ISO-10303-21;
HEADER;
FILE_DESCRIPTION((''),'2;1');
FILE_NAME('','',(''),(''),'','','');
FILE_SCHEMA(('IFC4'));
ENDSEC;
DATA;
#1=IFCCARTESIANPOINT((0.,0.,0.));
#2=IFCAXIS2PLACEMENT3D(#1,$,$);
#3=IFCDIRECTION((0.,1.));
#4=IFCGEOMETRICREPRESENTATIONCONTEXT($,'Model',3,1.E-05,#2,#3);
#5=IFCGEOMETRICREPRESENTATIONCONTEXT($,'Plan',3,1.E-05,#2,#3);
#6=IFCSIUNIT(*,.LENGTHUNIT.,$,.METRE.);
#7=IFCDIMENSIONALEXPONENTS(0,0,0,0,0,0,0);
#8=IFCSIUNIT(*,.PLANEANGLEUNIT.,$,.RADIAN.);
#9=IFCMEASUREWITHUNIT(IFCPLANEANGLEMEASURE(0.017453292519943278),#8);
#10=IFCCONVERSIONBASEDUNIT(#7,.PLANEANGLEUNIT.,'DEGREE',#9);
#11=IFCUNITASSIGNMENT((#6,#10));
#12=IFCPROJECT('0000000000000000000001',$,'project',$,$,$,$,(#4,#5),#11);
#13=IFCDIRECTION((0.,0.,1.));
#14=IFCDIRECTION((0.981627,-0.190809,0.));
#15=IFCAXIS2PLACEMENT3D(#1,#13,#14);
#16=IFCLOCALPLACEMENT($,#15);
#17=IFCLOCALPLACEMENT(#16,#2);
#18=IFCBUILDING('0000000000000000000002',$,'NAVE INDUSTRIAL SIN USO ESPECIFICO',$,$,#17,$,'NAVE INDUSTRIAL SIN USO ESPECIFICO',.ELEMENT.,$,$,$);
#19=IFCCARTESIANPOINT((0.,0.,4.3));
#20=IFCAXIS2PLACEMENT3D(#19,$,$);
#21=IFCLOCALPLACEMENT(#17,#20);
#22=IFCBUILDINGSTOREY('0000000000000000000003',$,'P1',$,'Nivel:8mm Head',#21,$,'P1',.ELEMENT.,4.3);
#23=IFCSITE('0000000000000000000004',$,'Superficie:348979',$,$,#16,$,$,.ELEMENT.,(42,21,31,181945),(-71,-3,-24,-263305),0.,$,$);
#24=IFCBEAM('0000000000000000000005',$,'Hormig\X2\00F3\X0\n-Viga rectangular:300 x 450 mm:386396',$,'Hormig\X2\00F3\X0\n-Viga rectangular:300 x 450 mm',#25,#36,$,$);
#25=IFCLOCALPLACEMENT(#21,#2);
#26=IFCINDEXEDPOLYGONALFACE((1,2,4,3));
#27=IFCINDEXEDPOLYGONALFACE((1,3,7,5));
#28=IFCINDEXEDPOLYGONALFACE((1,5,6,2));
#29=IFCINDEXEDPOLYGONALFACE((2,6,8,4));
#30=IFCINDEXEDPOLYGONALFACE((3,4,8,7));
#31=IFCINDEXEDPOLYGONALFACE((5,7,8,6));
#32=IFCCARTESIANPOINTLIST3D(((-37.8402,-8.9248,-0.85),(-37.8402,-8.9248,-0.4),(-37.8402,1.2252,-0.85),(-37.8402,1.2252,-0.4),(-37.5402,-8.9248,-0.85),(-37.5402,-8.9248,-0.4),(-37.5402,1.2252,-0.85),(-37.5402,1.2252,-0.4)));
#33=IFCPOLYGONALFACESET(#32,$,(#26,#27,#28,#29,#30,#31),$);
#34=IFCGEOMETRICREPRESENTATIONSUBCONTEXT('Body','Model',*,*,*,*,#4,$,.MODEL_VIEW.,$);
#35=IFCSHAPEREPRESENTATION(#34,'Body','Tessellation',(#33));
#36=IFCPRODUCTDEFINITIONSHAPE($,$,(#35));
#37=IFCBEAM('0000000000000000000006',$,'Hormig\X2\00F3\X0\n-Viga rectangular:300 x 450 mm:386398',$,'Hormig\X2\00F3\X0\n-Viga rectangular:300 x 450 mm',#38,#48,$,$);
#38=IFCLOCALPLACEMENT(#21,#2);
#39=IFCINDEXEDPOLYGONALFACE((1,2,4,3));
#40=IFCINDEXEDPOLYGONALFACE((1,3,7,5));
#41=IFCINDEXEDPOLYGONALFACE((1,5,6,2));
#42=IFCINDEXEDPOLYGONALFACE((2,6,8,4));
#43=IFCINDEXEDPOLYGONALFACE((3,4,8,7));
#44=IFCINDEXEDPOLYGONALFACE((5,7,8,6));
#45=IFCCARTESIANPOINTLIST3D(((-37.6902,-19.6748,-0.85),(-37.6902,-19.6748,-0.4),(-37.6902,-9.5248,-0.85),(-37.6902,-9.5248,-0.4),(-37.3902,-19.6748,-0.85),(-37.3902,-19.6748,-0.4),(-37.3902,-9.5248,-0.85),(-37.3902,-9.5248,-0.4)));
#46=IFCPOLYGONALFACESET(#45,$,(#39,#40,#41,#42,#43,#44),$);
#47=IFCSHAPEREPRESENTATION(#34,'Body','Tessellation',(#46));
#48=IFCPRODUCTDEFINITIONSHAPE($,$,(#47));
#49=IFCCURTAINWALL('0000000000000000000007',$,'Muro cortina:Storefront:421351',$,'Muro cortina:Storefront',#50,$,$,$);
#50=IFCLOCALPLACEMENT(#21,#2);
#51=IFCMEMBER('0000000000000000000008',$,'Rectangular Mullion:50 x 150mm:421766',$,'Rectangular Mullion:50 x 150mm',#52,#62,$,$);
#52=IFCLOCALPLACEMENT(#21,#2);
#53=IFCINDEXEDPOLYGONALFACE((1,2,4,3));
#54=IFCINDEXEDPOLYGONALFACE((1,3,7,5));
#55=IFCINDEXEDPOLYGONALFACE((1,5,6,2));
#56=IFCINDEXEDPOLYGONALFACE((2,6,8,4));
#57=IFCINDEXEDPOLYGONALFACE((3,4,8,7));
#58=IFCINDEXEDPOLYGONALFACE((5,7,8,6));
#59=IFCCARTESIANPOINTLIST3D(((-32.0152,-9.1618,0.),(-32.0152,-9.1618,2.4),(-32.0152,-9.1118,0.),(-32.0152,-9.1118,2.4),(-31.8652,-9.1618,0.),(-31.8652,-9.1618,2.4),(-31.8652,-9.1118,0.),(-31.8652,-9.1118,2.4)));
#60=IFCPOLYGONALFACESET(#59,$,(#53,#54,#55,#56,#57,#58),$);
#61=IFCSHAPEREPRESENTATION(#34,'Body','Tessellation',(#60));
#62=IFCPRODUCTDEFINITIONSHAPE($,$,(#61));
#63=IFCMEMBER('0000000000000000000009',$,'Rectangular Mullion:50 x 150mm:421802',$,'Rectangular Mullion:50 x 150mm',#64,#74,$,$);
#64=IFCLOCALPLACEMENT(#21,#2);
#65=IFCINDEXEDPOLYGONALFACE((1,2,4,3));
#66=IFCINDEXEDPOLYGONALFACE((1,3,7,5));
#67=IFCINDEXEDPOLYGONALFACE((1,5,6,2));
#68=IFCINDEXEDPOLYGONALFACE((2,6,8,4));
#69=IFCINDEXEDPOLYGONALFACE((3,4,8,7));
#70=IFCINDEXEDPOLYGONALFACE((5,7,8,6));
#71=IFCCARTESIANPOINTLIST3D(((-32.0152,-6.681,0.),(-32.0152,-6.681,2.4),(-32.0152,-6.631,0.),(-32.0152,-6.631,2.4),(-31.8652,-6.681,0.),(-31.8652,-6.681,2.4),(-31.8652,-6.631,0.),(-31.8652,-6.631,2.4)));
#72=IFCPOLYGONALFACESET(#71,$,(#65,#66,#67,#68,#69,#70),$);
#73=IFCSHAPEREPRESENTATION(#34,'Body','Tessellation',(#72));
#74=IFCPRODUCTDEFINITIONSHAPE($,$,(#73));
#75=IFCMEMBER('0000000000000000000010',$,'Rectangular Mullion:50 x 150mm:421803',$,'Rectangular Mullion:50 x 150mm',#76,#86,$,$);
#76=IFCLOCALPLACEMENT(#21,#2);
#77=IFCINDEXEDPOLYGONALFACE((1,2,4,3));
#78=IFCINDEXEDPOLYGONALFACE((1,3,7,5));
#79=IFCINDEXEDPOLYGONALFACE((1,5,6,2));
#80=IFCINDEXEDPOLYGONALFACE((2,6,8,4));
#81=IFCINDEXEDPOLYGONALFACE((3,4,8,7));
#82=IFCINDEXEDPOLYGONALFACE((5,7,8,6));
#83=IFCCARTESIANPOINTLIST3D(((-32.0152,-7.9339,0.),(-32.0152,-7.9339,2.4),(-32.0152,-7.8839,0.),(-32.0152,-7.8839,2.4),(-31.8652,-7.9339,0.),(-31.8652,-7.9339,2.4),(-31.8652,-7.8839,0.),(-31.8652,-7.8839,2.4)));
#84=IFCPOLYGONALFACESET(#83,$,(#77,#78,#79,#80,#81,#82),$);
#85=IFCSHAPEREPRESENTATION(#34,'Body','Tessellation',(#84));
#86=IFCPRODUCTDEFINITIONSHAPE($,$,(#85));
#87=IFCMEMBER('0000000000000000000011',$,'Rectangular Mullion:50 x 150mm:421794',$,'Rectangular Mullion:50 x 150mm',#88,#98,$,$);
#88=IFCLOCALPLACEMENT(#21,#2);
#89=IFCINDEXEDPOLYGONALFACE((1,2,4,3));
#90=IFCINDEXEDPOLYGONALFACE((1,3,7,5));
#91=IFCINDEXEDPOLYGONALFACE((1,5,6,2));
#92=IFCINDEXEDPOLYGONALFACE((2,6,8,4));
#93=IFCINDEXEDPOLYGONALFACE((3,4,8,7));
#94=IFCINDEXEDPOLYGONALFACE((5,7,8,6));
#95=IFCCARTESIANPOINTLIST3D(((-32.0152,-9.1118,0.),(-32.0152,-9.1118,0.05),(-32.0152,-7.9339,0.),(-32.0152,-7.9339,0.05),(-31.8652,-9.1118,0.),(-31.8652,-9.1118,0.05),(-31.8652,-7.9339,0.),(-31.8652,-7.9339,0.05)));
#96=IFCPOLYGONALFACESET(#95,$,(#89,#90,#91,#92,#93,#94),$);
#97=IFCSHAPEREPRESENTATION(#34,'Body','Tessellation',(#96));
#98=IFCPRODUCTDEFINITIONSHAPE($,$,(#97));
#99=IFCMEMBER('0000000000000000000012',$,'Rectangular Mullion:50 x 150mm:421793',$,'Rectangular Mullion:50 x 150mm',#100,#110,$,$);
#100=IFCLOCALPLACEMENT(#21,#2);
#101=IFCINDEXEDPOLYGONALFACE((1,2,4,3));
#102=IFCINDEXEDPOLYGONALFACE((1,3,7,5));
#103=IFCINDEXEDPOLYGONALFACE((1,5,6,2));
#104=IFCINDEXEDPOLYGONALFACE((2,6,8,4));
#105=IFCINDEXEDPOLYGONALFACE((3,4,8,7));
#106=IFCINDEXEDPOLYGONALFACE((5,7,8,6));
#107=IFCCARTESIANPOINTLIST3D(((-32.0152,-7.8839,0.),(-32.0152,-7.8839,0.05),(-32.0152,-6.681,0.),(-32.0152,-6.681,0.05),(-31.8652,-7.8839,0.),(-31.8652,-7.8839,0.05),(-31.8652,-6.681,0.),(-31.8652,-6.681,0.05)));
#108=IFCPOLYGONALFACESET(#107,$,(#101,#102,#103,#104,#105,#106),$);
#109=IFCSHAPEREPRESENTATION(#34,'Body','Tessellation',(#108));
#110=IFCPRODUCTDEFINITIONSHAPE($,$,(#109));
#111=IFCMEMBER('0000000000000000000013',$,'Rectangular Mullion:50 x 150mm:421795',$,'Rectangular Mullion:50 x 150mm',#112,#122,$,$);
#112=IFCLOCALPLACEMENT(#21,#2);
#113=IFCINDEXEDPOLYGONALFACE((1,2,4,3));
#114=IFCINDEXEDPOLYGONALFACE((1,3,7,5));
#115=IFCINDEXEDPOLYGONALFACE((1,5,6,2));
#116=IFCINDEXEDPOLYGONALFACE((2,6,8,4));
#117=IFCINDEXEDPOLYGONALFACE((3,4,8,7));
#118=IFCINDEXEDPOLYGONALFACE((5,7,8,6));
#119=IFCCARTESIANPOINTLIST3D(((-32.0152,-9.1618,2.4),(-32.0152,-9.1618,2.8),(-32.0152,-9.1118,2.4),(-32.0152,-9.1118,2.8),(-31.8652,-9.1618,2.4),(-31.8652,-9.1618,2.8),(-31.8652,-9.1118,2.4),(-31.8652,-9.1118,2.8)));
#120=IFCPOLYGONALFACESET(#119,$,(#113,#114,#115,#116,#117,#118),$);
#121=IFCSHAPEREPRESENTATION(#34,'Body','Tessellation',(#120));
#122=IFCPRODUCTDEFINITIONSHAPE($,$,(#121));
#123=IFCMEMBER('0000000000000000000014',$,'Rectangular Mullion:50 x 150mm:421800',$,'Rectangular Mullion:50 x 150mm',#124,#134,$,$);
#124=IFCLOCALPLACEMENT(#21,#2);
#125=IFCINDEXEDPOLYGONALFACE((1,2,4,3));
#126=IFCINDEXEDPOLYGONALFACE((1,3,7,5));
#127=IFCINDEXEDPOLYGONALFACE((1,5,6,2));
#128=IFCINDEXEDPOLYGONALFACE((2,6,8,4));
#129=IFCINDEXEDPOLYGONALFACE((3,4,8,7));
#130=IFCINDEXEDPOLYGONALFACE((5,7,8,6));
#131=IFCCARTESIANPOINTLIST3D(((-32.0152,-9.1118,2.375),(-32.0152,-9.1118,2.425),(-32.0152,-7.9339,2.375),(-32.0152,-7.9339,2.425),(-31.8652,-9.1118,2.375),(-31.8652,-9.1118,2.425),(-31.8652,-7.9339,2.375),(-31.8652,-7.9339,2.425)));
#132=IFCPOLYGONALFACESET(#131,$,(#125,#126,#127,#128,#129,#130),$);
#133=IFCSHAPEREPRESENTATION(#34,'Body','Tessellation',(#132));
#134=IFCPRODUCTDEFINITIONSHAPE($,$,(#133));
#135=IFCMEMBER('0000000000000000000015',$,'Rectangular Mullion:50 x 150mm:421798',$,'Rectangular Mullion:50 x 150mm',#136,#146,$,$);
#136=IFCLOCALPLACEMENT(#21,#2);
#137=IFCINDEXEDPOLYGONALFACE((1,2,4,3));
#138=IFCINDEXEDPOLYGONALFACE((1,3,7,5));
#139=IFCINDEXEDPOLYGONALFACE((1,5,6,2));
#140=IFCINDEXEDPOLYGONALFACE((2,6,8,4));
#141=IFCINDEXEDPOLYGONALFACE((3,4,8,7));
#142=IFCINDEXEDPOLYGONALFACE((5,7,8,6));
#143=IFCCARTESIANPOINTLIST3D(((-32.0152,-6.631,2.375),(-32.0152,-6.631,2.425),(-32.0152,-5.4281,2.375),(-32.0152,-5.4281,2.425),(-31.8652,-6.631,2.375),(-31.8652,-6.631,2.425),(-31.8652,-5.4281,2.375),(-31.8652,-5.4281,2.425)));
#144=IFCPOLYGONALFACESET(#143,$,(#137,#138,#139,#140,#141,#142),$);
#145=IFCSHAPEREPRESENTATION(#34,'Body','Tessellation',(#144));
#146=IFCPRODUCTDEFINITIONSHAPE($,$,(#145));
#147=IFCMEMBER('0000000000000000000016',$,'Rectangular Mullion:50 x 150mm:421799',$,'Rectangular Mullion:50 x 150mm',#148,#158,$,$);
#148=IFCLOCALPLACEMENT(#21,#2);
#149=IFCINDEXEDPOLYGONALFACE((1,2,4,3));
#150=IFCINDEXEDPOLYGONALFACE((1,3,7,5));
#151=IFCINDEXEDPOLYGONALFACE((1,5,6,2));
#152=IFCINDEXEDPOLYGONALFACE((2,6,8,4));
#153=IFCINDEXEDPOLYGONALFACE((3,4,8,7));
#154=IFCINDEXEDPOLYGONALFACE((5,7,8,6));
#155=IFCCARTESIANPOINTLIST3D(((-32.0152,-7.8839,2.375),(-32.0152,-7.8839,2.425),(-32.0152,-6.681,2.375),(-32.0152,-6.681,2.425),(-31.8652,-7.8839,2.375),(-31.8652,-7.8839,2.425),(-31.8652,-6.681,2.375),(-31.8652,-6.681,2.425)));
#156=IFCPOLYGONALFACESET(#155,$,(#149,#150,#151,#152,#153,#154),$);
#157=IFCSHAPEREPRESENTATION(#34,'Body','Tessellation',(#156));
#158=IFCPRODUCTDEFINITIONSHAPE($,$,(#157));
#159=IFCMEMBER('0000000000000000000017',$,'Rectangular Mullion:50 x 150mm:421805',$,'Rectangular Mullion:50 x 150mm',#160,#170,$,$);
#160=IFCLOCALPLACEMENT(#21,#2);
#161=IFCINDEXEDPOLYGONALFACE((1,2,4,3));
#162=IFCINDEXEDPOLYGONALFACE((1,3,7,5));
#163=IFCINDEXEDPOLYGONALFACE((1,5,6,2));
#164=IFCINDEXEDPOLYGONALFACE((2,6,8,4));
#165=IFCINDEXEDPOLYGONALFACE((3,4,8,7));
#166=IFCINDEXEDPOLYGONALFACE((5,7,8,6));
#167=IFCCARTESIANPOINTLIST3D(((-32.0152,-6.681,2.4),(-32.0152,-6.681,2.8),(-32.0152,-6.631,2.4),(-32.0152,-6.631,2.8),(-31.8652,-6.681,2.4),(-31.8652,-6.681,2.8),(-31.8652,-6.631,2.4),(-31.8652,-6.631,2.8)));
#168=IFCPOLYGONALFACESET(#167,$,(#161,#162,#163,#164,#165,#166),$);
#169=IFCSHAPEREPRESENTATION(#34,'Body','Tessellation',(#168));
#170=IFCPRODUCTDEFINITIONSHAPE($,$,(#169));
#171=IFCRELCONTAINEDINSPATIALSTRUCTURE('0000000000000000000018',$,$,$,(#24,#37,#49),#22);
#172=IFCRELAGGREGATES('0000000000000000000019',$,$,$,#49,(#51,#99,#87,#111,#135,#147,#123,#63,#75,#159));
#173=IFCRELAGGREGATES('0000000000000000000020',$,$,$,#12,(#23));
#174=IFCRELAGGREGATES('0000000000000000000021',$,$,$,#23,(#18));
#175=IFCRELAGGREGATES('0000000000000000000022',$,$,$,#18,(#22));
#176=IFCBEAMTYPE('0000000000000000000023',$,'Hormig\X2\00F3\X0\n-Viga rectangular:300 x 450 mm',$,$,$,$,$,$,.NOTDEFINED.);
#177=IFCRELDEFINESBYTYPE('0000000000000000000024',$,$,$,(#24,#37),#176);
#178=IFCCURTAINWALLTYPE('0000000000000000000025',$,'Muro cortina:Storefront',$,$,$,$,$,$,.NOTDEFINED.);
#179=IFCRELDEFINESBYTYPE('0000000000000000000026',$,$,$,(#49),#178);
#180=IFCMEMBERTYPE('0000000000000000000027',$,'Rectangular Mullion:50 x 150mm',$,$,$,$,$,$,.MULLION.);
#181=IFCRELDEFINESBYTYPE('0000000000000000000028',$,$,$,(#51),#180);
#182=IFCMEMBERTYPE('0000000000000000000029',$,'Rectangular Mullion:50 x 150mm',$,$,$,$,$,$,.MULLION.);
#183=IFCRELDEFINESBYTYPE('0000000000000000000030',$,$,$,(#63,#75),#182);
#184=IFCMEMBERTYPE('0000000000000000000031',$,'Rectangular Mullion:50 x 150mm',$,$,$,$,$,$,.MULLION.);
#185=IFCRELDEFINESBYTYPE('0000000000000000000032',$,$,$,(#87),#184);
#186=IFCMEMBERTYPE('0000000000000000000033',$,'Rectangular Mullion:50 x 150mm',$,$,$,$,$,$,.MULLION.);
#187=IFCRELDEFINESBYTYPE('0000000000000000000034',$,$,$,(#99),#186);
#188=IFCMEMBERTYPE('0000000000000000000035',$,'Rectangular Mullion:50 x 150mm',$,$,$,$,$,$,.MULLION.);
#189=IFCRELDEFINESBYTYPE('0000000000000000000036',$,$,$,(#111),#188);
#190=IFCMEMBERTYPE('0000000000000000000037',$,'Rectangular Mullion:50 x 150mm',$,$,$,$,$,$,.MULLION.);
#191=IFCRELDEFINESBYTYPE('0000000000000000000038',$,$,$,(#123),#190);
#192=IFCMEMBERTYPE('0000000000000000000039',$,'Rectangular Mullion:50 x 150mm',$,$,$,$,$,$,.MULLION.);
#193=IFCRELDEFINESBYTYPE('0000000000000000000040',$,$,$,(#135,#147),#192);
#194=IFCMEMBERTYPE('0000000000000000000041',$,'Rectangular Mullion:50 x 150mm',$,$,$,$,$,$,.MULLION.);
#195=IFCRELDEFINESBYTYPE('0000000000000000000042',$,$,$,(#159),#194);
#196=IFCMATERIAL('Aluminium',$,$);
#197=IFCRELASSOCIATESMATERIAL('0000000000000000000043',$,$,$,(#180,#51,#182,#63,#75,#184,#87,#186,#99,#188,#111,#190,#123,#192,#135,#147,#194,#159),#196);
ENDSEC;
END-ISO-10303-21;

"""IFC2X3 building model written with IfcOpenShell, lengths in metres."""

from ifc_helpers import new_model, entity, si_unit, converted_unit, direction, frame, frame_2d, origin, origin_2d_with_axis, place, context, subcontext, project, spatial, rectangle, extrude, source, transform, mapped, material, type_object, type_shapes, element, aggregate, save


model = new_model("IFC2X3")

# Units and contexts
model_context = context("Model", 3, precision=1e-05, world=origin(), true_north=direction((0.0, 1.0)))
plan_context = context("Plan", 3, precision=1e-05, world=origin(), true_north=direction((0.0, 1.0)))
body_context = subcontext(model_context, "Body", "Model", "MODEL_VIEW")
ifc_project = project(units=[si_unit("LENGTHUNIT", "METRE"), converted_unit("PLANEANGLEUNIT", "DEGREE", entity("IfcPlaneAngleMeasure", 0.017453292519943278), si_unit("PLANEANGLEUNIT", "RADIAN"), dimensions=[0, 0, 0, 0, 0, 0, 0])], contexts=[model_context, plan_context])

# Site, building, storey
site_placement = place(None, frame((0.0, 0.0, 0.0), z_axis=(0.0, 0.0, 1.0), x_axis=(0.981627, -0.190809, 0.0)))
site = spatial("IfcSite", under=ifc_project, at=site_placement, Name="Superficie:348979", CompositionType="ELEMENT", RefLatitude=(42, 21, 31, 181945), RefLongitude=(-71, -3, -24, -263305), RefElevation=0.0)
building_placement = place(site_placement, origin())
building = spatial("IfcBuilding", under=site, at=building_placement, Name="NAVE INDUSTRIAL SIN USO ESPECIFICO", LongName="NAVE INDUSTRIAL SIN USO ESPECIFICO", CompositionType="ELEMENT")
storey_placement = place(building_placement, frame((0.0, 0.0, 4.3)))
storey = spatial("IfcBuildingStorey", under=building, at=storey_placement, Name="P1", ObjectType="Nivel:8mm Head", LongName="P1", CompositionType="ELEMENT", Elevation=4.3)

# Beams
beam_type = type_object("IfcBeamType", Name="Hormigón-Viga rectangular:300 x 450 mm", PredefinedType="NOTDEFINED")
beam_1_placement = place(storey_placement, frame((-37.6902, 1.5252, -0.4), z_axis=(0.0, 0.0, 1.0), x_axis=(0.0, -1.0, 0.0)))
element("IfcBeam", 1, at=beam_1_placement, inside=storey, type_object=beam_type, Name="Hormigón-Viga rectangular:300 x 450 mm:386396", ObjectType="Hormigón-Viga rectangular:300 x 450 mm", context=body_context, shape_type="SweptSolid", body=[
    extrude(rectangle(XDim=0.45, YDim=0.3, at=frame_2d((0.0, 0.0), x_axis=(1.0, 0.0))), frame((0.3, 0.0, -0.225), z_axis=(1.0, 0.0, 0.0), x_axis=(0.0, 0.0, -1.0)), (0.0, 0.0, 1.0), 10.15),
])
beam_2_placement = place(storey_placement, frame((-37.5402, -9.2248, -0.4), z_axis=(0.0, 0.0, 1.0), x_axis=(0.0, -1.0, 0.0)))
element("IfcBeam", 2, at=beam_2_placement, inside=storey, type_object=beam_type, Name="Hormigón-Viga rectangular:300 x 450 mm:386398", ObjectType="Hormigón-Viga rectangular:300 x 450 mm", context=body_context, shape_type="SweptSolid", body=[
    extrude(rectangle(XDim=0.45, YDim=0.3, at=frame_2d((0.0, 0.0), x_axis=(1.0, 0.0))), frame((0.3, 0.0, -0.225), z_axis=(1.0, 0.0, 0.0), x_axis=(0.0, 0.0, -1.0)), (0.0, 0.0, 1.0), 10.15),
])

# Curtain wall, members
curtain_wall_type = type_object("IfcCurtainWallType", Name="Muro cortina:Storefront", PredefinedType="NOTDEFINED")
curtain_wall_placement = place(storey_placement, frame((0.0, 0.0, -4.3)))
curtain_wall = element("IfcCurtainWall", 3, at=curtain_wall_placement, inside=storey, type_object=curtain_wall_type, Name="Muro cortina:Storefront:421351", ObjectType="Muro cortina:Storefront")
ifc_material_1 = material(Name="Aluminium")
member_type_1 = type_object("IfcMemberType", Name="Rectangular Mullion:50 x 150mm", PredefinedType="MULLION", material=ifc_material_1)
shared_shape_1 = source(origin(), body_context, "Body", "SweptSolid", [
    extrude(rectangle(XDim=0.05, YDim=0.15, at=origin_2d_with_axis()), frame((-0.025, 0.0, -2.4), z_axis=(0.0, 0.0, 1.0), x_axis=(-1.0, 0.0, 0.0)), (0.0, 0.0, 1.0), 2.4),
])
type_shapes(member_type_1, [shared_shape_1])
member_1_placement = place(curtain_wall_placement, frame((-31.9402, -9.1618, 4.3), z_axis=(0.0, 0.0, -1.0), x_axis=(0.0, -1.0, 0.0)))
member_1 = element("IfcMember", 4, at=member_1_placement, type_object=member_type_1, material=ifc_material_1, Name="Rectangular Mullion:50 x 150mm:421766", ObjectType="Rectangular Mullion:50 x 150mm", context=body_context, shape_type="MappedRepresentation", body=[
    mapped(shared_shape_1, transform((0.0, 0.0, 0.0), scale=1.0)),
])
member_type_2 = type_object("IfcMemberType", Name="Rectangular Mullion:50 x 150mm", PredefinedType="MULLION", material=ifc_material_1)
shared_shape_2 = source(origin(), body_context, "Body", "SweptSolid", [
    extrude(rectangle(XDim=0.05, YDim=0.15, at=origin_2d_with_axis()), frame((0.0, 0.0, -2.4), z_axis=(0.0, 0.0, 1.0), x_axis=(-1.0, 0.0, 0.0)), (0.0, 0.0, 1.0), 2.4),
])
type_shapes(member_type_2, [shared_shape_2])
member_2_placement = place(curtain_wall_placement, frame((-31.9402, -6.656, 4.3), z_axis=(0.0, 0.0, -1.0), x_axis=(0.0, -1.0, 0.0)))
member_2 = element("IfcMember", 5, at=member_2_placement, type_object=member_type_2, material=ifc_material_1, Name="Rectangular Mullion:50 x 150mm:421802", ObjectType="Rectangular Mullion:50 x 150mm", context=body_context, shape_type="MappedRepresentation", body=[
    mapped(shared_shape_2, transform((0.0, 0.0, 0.0), scale=1.0)),
])
member_3_placement = place(curtain_wall_placement, frame((-31.9402, -7.9089, 4.3), z_axis=(0.0, 0.0, -1.0), x_axis=(0.0, -1.0, 0.0)))
member_3 = element("IfcMember", 6, at=member_3_placement, type_object=member_type_2, material=ifc_material_1, Name="Rectangular Mullion:50 x 150mm:421803", ObjectType="Rectangular Mullion:50 x 150mm", context=body_context, shape_type="MappedRepresentation", body=[
    mapped(shared_shape_2, transform((0.0, 0.0, 0.0), scale=1.0)),
])
member_type_3 = type_object("IfcMemberType", Name="Rectangular Mullion:50 x 150mm", PredefinedType="MULLION", material=ifc_material_1)
shared_shape_3 = source(origin(), body_context, "Body", "SweptSolid", [
    extrude(rectangle(XDim=0.05, YDim=0.15, at=origin_2d_with_axis()), frame((-0.025, 0.0, -1.1779), z_axis=(0.0, 0.0, 1.0), x_axis=(-1.0, 0.0, 0.0)), (0.0, 0.0, 1.0), 1.1779),
])
type_shapes(member_type_3, [shared_shape_3])
member_4_placement = place(curtain_wall_placement, frame((-31.9402, -7.9339, 4.3), z_axis=(0.0, 1.0, 0.0), x_axis=(0.0, 0.0, -1.0)))
member_4 = element("IfcMember", 7, at=member_4_placement, type_object=member_type_3, material=ifc_material_1, Name="Rectangular Mullion:50 x 150mm:421794", ObjectType="Rectangular Mullion:50 x 150mm", context=body_context, shape_type="MappedRepresentation", body=[
    mapped(shared_shape_3, transform((0.0, 0.0, 0.0), scale=1.0)),
])
member_type_4 = type_object("IfcMemberType", Name="Rectangular Mullion:50 x 150mm", PredefinedType="MULLION", material=ifc_material_1)
shared_shape_4 = source(origin(), body_context, "Body", "SweptSolid", [
    extrude(rectangle(XDim=0.05, YDim=0.15, at=origin_2d_with_axis()), frame((-0.025, 0.0, -1.2029), z_axis=(0.0, 0.0, 1.0), x_axis=(-1.0, 0.0, 0.0)), (0.0, 0.0, 1.0), 1.2029),
])
type_shapes(member_type_4, [shared_shape_4])
member_5_placement = place(curtain_wall_placement, frame((-31.9402, -6.681, 4.3), z_axis=(0.0, 1.0, 0.0), x_axis=(0.0, 0.0, -1.0)))
member_5 = element("IfcMember", 8, at=member_5_placement, type_object=member_type_4, material=ifc_material_1, Name="Rectangular Mullion:50 x 150mm:421793", ObjectType="Rectangular Mullion:50 x 150mm", context=body_context, shape_type="MappedRepresentation", body=[
    mapped(shared_shape_4, transform((0.0, 0.0, 0.0), scale=1.0)),
])
member_type_5 = type_object("IfcMemberType", Name="Rectangular Mullion:50 x 150mm", PredefinedType="MULLION", material=ifc_material_1)
shared_shape_5 = source(origin(), body_context, "Body", "SweptSolid", [
    extrude(rectangle(XDim=0.05, YDim=0.15, at=origin_2d_with_axis()), frame((-0.025, 0.0, -0.4), z_axis=(0.0, 0.0, 1.0), x_axis=(-1.0, 0.0, 0.0)), (0.0, 0.0, 1.0), 0.4),
])
type_shapes(member_type_5, [shared_shape_5])
member_6_placement = place(curtain_wall_placement, frame((-31.9402, -9.1618, 6.7), z_axis=(0.0, 0.0, -1.0), x_axis=(0.0, -1.0, 0.0)))
member_6 = element("IfcMember", 9, at=member_6_placement, type_object=member_type_5, material=ifc_material_1, Name="Rectangular Mullion:50 x 150mm:421795", ObjectType="Rectangular Mullion:50 x 150mm", context=body_context, shape_type="MappedRepresentation", body=[
    mapped(shared_shape_5, transform((0.0, 0.0, 0.0), scale=1.0)),
])
member_type_6 = type_object("IfcMemberType", Name="Rectangular Mullion:50 x 150mm", PredefinedType="MULLION", material=ifc_material_1)
shared_shape_6 = source(origin(), body_context, "Body", "SweptSolid", [
    extrude(rectangle(XDim=0.05, YDim=0.15, at=origin_2d_with_axis()), frame((0.0, 0.0, -1.1779), z_axis=(0.0, 0.0, 1.0), x_axis=(-1.0, 0.0, 0.0)), (0.0, 0.0, 1.0), 1.1779),
])
type_shapes(member_type_6, [shared_shape_6])
member_7_placement = place(curtain_wall_placement, frame((-31.9402, -9.1118, 6.7), z_axis=(0.0, -1.0, 0.0), x_axis=(0.0, 0.0, 1.0)))
member_7 = element("IfcMember", 10, at=member_7_placement, type_object=member_type_6, material=ifc_material_1, Name="Rectangular Mullion:50 x 150mm:421800", ObjectType="Rectangular Mullion:50 x 150mm", context=body_context, shape_type="MappedRepresentation", body=[
    mapped(shared_shape_6, transform((0.0, 0.0, 0.0), scale=1.0)),
])
member_type_7 = type_object("IfcMemberType", Name="Rectangular Mullion:50 x 150mm", PredefinedType="MULLION", material=ifc_material_1)
shared_shape_7 = source(origin(), body_context, "Body", "SweptSolid", [
    extrude(rectangle(XDim=0.05, YDim=0.15, at=origin_2d_with_axis()), frame((0.0, 0.0, -1.2029), z_axis=(0.0, 0.0, 1.0), x_axis=(-1.0, 0.0, 0.0)), (0.0, 0.0, 1.0), 1.2029),
])
type_shapes(member_type_7, [shared_shape_7])
member_8_placement = place(curtain_wall_placement, frame((-31.9402, -6.631, 6.7), z_axis=(0.0, -1.0, 0.0), x_axis=(0.0, 0.0, 1.0)))
member_8 = element("IfcMember", 11, at=member_8_placement, type_object=member_type_7, material=ifc_material_1, Name="Rectangular Mullion:50 x 150mm:421798", ObjectType="Rectangular Mullion:50 x 150mm", context=body_context, shape_type="MappedRepresentation", body=[
    mapped(shared_shape_7, transform((0.0, 0.0, 0.0), scale=1.0)),
])
member_9_placement = place(curtain_wall_placement, frame((-31.9402, -7.8839, 6.7), z_axis=(0.0, -1.0, 0.0), x_axis=(0.0, 0.0, 1.0)))
member_9 = element("IfcMember", 12, at=member_9_placement, type_object=member_type_7, material=ifc_material_1, Name="Rectangular Mullion:50 x 150mm:421799", ObjectType="Rectangular Mullion:50 x 150mm", context=body_context, shape_type="MappedRepresentation", body=[
    mapped(shared_shape_7, transform((0.0, 0.0, 0.0), scale=1.0)),
])
member_type_8 = type_object("IfcMemberType", Name="Rectangular Mullion:50 x 150mm", PredefinedType="MULLION", material=ifc_material_1)
shared_shape_8 = source(origin(), body_context, "Body", "SweptSolid", [
    extrude(rectangle(XDim=0.05, YDim=0.15, at=origin_2d_with_axis()), frame((0.0, 0.0, -0.4), z_axis=(0.0, 0.0, 1.0), x_axis=(-1.0, 0.0, 0.0)), (0.0, 0.0, 1.0), 0.4),
])
type_shapes(member_type_8, [shared_shape_8])
member_10_placement = place(curtain_wall_placement, frame((-31.9402, -6.656, 6.7), z_axis=(0.0, 0.0, -1.0), x_axis=(0.0, -1.0, 0.0)))
member_10 = element("IfcMember", 13, at=member_10_placement, type_object=member_type_8, material=ifc_material_1, Name="Rectangular Mullion:50 x 150mm:421805", ObjectType="Rectangular Mullion:50 x 150mm", context=body_context, shape_type="MappedRepresentation", body=[
    mapped(shared_shape_8, transform((0.0, 0.0, 0.0), scale=1.0)),
])
aggregate(curtain_wall, [member_1, member_5, member_4, member_6, member_8, member_9, member_7, member_2, member_3, member_10])

save(model, "model.ifc")
